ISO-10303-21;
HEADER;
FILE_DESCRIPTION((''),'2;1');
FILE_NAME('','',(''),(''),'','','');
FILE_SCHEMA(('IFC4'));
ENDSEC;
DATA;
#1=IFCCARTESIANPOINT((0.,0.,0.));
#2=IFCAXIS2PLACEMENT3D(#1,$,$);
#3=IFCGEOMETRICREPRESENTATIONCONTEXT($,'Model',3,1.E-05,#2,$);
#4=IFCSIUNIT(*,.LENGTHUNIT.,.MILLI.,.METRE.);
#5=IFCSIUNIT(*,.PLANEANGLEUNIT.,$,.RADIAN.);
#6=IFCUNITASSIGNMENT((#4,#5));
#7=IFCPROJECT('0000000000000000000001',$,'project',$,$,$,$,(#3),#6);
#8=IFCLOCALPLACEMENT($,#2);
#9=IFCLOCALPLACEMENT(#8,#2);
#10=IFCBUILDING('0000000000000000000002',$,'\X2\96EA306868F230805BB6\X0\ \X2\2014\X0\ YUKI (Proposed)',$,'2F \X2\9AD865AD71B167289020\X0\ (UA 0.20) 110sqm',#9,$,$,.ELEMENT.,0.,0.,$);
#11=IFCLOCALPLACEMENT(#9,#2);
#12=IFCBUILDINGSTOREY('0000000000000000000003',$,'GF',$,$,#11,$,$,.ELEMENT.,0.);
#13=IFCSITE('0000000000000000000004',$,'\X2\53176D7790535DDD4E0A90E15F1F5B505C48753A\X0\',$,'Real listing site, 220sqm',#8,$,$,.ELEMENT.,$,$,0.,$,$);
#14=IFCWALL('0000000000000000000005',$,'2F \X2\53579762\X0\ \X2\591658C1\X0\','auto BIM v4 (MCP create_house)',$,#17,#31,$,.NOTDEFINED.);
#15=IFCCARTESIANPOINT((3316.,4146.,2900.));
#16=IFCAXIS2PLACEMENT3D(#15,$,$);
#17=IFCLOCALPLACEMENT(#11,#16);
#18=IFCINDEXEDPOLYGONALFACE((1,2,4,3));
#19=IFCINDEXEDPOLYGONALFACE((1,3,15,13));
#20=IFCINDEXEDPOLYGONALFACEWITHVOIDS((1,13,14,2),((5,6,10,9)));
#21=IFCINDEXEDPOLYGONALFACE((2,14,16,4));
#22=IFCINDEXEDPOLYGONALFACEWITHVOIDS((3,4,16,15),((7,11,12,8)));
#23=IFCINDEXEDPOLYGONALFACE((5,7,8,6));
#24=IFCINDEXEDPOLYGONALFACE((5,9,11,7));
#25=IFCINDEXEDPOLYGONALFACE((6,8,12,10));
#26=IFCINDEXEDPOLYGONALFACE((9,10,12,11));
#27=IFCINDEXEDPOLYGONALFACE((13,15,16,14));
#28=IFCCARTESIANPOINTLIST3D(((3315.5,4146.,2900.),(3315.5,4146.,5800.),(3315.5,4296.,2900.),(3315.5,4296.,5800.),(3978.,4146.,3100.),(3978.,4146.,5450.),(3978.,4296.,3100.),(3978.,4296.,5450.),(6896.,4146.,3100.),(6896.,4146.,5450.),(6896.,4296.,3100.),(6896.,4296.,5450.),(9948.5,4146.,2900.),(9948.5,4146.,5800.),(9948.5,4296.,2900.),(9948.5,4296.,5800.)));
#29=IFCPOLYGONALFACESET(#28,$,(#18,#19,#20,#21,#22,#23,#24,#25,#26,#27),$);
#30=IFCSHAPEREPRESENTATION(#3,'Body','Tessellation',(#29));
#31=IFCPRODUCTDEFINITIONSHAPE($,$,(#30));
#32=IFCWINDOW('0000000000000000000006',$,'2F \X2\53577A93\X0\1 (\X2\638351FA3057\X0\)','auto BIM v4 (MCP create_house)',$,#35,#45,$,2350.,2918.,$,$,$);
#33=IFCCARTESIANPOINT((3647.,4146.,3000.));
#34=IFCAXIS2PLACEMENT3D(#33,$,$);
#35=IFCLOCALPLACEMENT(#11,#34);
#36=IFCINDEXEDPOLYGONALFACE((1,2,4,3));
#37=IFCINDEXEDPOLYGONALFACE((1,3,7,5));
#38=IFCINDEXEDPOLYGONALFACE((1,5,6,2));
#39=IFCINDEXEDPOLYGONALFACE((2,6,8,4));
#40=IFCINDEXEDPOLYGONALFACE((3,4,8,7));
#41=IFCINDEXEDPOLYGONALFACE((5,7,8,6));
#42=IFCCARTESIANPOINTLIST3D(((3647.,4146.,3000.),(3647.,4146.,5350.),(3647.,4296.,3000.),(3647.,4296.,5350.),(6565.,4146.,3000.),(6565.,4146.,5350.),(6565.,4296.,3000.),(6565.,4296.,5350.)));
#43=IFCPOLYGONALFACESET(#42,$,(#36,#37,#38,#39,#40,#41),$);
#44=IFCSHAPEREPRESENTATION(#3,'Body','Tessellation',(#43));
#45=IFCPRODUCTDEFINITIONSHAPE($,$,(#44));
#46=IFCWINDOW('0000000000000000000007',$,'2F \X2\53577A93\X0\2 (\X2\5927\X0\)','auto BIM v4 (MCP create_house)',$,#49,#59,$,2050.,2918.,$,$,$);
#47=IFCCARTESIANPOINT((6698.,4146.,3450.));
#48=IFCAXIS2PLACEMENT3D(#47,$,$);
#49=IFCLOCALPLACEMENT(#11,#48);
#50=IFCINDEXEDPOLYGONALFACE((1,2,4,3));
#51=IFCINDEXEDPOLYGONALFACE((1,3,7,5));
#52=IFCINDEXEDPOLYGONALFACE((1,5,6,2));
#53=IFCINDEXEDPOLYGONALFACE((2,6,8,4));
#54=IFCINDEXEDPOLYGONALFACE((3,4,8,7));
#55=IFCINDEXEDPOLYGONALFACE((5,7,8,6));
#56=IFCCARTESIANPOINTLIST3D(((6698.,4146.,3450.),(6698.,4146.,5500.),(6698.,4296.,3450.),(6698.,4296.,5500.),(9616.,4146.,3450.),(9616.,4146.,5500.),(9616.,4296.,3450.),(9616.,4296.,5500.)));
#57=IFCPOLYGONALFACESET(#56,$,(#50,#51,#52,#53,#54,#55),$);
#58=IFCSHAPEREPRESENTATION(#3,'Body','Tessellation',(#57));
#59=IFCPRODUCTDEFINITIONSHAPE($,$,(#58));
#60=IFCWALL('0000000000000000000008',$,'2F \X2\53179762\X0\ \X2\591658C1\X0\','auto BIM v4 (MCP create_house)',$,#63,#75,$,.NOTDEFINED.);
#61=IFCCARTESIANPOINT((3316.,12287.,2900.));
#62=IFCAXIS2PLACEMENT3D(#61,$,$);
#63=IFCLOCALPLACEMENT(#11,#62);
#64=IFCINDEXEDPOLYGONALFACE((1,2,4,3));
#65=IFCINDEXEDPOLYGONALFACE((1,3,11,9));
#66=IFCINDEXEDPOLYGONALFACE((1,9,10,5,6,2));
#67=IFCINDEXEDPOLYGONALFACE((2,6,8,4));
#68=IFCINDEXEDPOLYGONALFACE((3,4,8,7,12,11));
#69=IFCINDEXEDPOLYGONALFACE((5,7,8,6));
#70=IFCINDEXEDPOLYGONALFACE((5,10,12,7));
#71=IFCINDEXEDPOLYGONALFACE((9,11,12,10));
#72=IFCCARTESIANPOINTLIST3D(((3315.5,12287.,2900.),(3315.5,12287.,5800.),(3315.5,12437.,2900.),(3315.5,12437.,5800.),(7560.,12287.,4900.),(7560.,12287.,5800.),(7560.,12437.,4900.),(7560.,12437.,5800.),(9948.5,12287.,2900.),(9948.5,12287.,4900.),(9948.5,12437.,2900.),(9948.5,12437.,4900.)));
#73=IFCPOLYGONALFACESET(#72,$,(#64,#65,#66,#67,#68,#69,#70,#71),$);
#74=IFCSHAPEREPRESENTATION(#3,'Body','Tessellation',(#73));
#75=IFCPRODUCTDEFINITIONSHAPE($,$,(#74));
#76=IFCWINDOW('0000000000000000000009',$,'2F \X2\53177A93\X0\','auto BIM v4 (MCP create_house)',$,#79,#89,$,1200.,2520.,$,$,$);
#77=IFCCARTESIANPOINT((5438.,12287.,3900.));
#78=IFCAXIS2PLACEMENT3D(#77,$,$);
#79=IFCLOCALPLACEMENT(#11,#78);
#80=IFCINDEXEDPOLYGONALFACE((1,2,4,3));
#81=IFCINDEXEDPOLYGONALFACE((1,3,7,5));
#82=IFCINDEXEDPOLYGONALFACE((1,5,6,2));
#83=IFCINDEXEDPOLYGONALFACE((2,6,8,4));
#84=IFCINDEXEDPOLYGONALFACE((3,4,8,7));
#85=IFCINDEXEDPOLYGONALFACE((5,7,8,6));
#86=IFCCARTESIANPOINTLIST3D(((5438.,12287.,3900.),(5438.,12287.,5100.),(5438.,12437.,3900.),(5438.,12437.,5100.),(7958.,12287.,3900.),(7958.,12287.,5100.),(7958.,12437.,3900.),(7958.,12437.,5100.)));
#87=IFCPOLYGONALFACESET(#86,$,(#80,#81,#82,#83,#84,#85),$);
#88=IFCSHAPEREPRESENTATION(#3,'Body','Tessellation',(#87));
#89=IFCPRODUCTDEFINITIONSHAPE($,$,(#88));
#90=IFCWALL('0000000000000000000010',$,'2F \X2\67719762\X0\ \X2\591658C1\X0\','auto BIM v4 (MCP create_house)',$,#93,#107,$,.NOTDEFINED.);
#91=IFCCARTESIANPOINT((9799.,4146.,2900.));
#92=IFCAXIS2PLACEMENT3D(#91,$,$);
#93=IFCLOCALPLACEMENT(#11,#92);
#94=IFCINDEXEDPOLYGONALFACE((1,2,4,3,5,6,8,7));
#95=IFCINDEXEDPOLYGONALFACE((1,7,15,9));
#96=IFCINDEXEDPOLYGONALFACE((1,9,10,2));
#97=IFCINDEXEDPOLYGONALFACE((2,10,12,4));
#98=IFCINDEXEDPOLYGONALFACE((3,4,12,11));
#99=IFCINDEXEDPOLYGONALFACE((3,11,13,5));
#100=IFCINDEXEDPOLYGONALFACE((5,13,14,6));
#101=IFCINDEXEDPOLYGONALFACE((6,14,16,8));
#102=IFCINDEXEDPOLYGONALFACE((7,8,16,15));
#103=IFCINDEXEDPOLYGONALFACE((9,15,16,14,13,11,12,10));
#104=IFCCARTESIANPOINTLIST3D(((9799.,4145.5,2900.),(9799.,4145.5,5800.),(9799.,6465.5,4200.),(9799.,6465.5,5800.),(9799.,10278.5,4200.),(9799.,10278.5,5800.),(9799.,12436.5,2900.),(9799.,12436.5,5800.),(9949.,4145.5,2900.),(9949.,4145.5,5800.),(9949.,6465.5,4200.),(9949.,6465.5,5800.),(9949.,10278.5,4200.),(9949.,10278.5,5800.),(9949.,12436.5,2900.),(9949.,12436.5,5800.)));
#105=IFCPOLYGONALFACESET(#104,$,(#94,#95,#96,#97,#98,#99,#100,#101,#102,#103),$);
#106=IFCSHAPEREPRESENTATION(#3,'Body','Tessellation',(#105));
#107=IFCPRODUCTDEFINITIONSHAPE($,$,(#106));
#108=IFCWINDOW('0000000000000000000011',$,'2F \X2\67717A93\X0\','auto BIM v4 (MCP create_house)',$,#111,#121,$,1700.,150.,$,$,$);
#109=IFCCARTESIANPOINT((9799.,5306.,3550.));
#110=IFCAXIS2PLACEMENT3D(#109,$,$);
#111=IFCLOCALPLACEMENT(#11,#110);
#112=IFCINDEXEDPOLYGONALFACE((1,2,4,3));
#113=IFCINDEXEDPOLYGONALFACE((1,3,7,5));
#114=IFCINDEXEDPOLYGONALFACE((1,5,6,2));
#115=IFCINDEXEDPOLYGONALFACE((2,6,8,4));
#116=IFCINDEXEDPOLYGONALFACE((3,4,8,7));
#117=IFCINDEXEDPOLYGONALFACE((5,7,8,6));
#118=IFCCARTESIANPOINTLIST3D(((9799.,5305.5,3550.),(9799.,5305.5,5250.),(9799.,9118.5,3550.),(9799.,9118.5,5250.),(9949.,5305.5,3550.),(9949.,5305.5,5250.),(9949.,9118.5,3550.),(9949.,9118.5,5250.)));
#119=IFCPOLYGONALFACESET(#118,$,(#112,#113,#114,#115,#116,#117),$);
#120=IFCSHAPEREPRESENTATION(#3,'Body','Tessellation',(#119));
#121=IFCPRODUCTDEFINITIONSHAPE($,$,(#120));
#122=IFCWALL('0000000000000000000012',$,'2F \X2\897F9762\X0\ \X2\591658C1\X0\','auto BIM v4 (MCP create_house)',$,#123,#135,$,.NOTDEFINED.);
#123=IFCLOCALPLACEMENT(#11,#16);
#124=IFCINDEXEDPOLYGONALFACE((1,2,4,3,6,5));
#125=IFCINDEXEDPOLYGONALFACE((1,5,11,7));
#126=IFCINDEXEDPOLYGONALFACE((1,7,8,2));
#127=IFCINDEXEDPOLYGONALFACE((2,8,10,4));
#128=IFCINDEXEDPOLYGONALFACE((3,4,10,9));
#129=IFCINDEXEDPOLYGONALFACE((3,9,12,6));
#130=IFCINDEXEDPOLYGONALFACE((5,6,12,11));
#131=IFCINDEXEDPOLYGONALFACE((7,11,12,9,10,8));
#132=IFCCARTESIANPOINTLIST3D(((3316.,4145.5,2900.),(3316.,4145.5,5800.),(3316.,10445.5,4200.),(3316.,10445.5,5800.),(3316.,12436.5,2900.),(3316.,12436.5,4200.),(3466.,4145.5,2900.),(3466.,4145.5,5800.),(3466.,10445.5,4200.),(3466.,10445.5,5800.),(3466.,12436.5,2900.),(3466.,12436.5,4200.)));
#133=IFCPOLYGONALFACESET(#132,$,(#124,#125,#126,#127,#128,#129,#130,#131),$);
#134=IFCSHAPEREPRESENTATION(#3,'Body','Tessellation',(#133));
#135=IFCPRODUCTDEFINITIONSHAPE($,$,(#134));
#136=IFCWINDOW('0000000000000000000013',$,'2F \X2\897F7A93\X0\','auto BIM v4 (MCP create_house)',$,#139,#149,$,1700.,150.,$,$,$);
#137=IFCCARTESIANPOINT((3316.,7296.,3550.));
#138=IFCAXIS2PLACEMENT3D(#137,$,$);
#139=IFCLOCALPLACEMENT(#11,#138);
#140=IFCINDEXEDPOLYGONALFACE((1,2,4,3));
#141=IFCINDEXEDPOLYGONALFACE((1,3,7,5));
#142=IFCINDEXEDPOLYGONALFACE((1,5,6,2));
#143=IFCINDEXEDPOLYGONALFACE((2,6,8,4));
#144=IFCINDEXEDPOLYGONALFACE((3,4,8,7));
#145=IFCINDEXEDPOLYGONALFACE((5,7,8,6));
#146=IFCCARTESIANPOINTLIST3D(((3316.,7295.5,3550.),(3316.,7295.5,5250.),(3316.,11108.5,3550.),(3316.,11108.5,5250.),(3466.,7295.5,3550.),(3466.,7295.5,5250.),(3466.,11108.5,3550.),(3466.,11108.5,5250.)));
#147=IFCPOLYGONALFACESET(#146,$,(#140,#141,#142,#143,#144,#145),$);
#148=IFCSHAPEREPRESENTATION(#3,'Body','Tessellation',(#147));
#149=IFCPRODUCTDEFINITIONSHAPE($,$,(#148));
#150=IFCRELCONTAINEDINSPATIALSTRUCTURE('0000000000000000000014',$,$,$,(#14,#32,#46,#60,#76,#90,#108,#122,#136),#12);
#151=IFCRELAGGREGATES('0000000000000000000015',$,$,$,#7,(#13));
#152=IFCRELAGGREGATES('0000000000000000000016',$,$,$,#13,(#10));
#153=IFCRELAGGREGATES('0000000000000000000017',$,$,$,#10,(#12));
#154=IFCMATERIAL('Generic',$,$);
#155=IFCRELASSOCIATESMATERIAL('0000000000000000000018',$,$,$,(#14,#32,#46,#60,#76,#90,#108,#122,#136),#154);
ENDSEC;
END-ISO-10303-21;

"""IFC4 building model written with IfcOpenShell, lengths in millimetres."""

from ifc_helpers import new_model, si_unit, frame, frame_2d, origin, place, context, project, spatial, rectangle, extrude, material, element, fill, save


model = new_model("IFC4")

# Units and contexts
model_context = context("Model", 3, precision=1e-05, world=origin())
ifc_project = project(units=[si_unit("LENGTHUNIT", "METRE", prefix="MILLI"), si_unit("PLANEANGLEUNIT", "RADIAN")], contexts=[model_context])

# Site, building, storey
site_placement = place(None, origin())
site = spatial("IfcSite", under=ifc_project, at=site_placement, Name="北海道川上郡弟子屈町", ObjectType="Real listing site, 220sqm", CompositionType="ELEMENT", RefElevation=0.0)
building_placement = place(site_placement, origin())
building = spatial("IfcBuilding", under=site, at=building_placement, Name="雪と棲む家 — YUKI (Proposed)", ObjectType="2F 高断熱木造 (UA 0.20) 110sqm", CompositionType="ELEMENT", ElevationOfRefHeight=0.0, ElevationOfTerrain=0.0)
storey_placement = place(building_placement, origin())
storey = spatial("IfcBuildingStorey", under=building, at=storey_placement, Name="GF", CompositionType="ELEMENT", Elevation=0.0)

# Shared definitions
ifc_material = material(Name="Generic")

# Wall, openings, windows
wall_1_placement = place(storey_placement, frame((3316.0, 4146.0, 2900.0)))
wall_1 = element("IfcWall", 1, at=wall_1_placement, inside=storey, material=ifc_material, Name="2F 南面 外壁", Description="auto BIM v4 (MCP create_house)", PredefinedType="NOTDEFINED", context=model_context, shape_type="SweptSolid", body=[
    extrude(rectangle(XDim=6633.0, YDim=150.0, at=frame_2d((3316.0, 75.0))), frame((3316.0, 4146.0, 2900.0)), (0.0, 0.0, 1.0), 2900.0),
])
opening_1_placement = place(storey_placement, frame((3647.0, 4146.0, 3000.0)))
opening_1 = element("IfcOpeningElement", 2, at=opening_1_placement, cuts=wall_1, PredefinedType="NOTDEFINED", context=model_context, shape_type="SweptSolid", body=[
    extrude(rectangle(XDim=2918.0, YDim=150.0, at=frame_2d((1459.0, 75.0))), frame((3647.0, 4146.0, 3000.0)), (0.0, 0.0, 1.0), 2350.0),
])
opening_2_placement = place(storey_placement, frame((6698.0, 4146.0, 3450.0)))
opening_2 = element("IfcOpeningElement", 3, at=opening_2_placement, cuts=wall_1, PredefinedType="NOTDEFINED", context=model_context, shape_type="SweptSolid", body=[
    extrude(rectangle(XDim=2918.0, YDim=150.0, at=frame_2d((1459.0, 75.0))), frame((6698.0, 4146.0, 3450.0)), (0.0, 0.0, 1.0), 2050.0),
])
window_1_placement = place(storey_placement, frame((3647.0, 4146.0, 3000.0)))
window_1 = element("IfcWindow", 4, at=window_1_placement, inside=storey, material=ifc_material, Name="2F 南窓1 (掃出し)", Description="auto BIM v4 (MCP create_house)", OverallHeight=2350.0, OverallWidth=2918.0, context=model_context, shape_type="SweptSolid", body=[
    extrude(rectangle(XDim=2918.0, YDim=150.0, at=frame_2d((1459.0, 75.0))), frame((3647.0, 4146.0, 3000.0)), (0.0, 0.0, 1.0), 2350.0),
])
fill(opening_1, window_1)
window_2_placement = place(storey_placement, frame((6698.0, 4146.0, 3450.0)))
window_2 = element("IfcWindow", 5, at=window_2_placement, inside=storey, material=ifc_material, Name="2F 南窓2 (大)", Description="auto BIM v4 (MCP create_house)", OverallHeight=2050.0, OverallWidth=2918.0, context=model_context, shape_type="SweptSolid", body=[
    extrude(rectangle(XDim=2918.0, YDim=150.0, at=frame_2d((1459.0, 75.0))), frame((6698.0, 4146.0, 3450.0)), (0.0, 0.0, 1.0), 2050.0),
])
fill(opening_2, window_2)

# Walls, openings, windows
wall_2_placement = place(storey_placement, frame((3316.0, 12287.0, 2900.0)))
wall_2 = element("IfcWall", 6, at=wall_2_placement, inside=storey, material=ifc_material, Name="2F 北面 外壁", Description="auto BIM v4 (MCP create_house)", PredefinedType="NOTDEFINED", context=model_context, shape_type="SweptSolid", body=[
    extrude(rectangle(XDim=6633.0, YDim=150.0, at=frame_2d((3316.0, 75.0))), frame((3316.0, 12287.0, 2900.0)), (0.0, 0.0, 1.0), 2900.0),
])
opening_3_placement = place(storey_placement, frame((5438.0, 12287.0, 3900.0)))
opening_3 = element("IfcOpeningElement", 7, at=opening_3_placement, cuts=wall_2, PredefinedType="NOTDEFINED", context=model_context, shape_type="SweptSolid", body=[
    extrude(rectangle(XDim=2520.0, YDim=150.0, at=frame_2d((1260.0, 75.0))), frame((5438.0, 12287.0, 3900.0)), (0.0, 0.0, 1.0), 1200.0),
])
window_3_placement = place(storey_placement, frame((5438.0, 12287.0, 3900.0)))
window_3 = element("IfcWindow", 8, at=window_3_placement, inside=storey, material=ifc_material, Name="2F 北窓", Description="auto BIM v4 (MCP create_house)", OverallHeight=1200.0, OverallWidth=2520.0, context=model_context, shape_type="SweptSolid", body=[
    extrude(rectangle(XDim=2520.0, YDim=150.0, at=frame_2d((1260.0, 75.0))), frame((5438.0, 12287.0, 3900.0)), (0.0, 0.0, 1.0), 1200.0),
])
fill(opening_3, window_3)
wall_3_placement = place(storey_placement, frame((9799.0, 4146.0, 2900.0)))
wall_3 = element("IfcWall", 9, at=wall_3_placement, inside=storey, material=ifc_material, Name="2F 東面 外壁", Description="auto BIM v4 (MCP create_house)", PredefinedType="NOTDEFINED", context=model_context, shape_type="SweptSolid", body=[
    extrude(rectangle(XDim=150.0, YDim=8291.0, at=frame_2d((75.0, 4145.0))), frame((9799.0, 4146.0, 2900.0)), (0.0, 0.0, 1.0), 2900.0),
])
opening_4_placement = place(storey_placement, frame((9799.0, 5306.0, 3550.0)))
opening_4 = element("IfcOpeningElement", 10, at=opening_4_placement, cuts=wall_3, PredefinedType="NOTDEFINED", context=model_context, shape_type="SweptSolid", body=[
    extrude(rectangle(XDim=150.0, YDim=3813.0, at=frame_2d((75.0, 1906.0))), frame((9799.0, 5306.0, 3550.0)), (0.0, 0.0, 1.0), 1700.0),
])
window_4_placement = place(storey_placement, frame((9799.0, 5306.0, 3550.0)))
window_4 = element("IfcWindow", 11, at=window_4_placement, inside=storey, material=ifc_material, Name="2F 東窓", Description="auto BIM v4 (MCP create_house)", OverallHeight=1700.0, OverallWidth=150.0, context=model_context, shape_type="SweptSolid", body=[
    extrude(rectangle(XDim=150.0, YDim=3813.0, at=frame_2d((75.0, 1906.0))), frame((9799.0, 5306.0, 3550.0)), (0.0, 0.0, 1.0), 1700.0),
])
fill(opening_4, window_4)
wall_4_placement = place(storey_placement, frame((3316.0, 4146.0, 2900.0)))
wall_4 = element("IfcWall", 12, at=wall_4_placement, inside=storey, material=ifc_material, Name="2F 西面 外壁", Description="auto BIM v4 (MCP create_house)", PredefinedType="NOTDEFINED", context=model_context, shape_type="SweptSolid", body=[
    extrude(rectangle(XDim=150.0, YDim=8291.0, at=frame_2d((75.0, 4145.0))), frame((3316.0, 4146.0, 2900.0)), (0.0, 0.0, 1.0), 2900.0),
])
opening_5_placement = place(storey_placement, frame((3316.0, 7296.0, 3550.0)))
opening_5 = element("IfcOpeningElement", 13, at=opening_5_placement, cuts=wall_4, PredefinedType="NOTDEFINED", context=model_context, shape_type="SweptSolid", body=[
    extrude(rectangle(XDim=150.0, YDim=3813.0, at=frame_2d((75.0, 1906.0))), frame((3316.0, 7296.0, 3550.0)), (0.0, 0.0, 1.0), 1700.0),
])
window_5_placement = place(storey_placement, frame((3316.0, 7296.0, 3550.0)))
window_5 = element("IfcWindow", 14, at=window_5_placement, inside=storey, material=ifc_material, Name="2F 西窓", Description="auto BIM v4 (MCP create_house)", OverallHeight=1700.0, OverallWidth=150.0, context=model_context, shape_type="SweptSolid", body=[
    extrude(rectangle(XDim=150.0, YDim=3813.0, at=frame_2d((75.0, 1906.0))), frame((3316.0, 7296.0, 3550.0)), (0.0, 0.0, 1.0), 1700.0),
])
fill(opening_5, window_5)

save(model, "model.ifc")
